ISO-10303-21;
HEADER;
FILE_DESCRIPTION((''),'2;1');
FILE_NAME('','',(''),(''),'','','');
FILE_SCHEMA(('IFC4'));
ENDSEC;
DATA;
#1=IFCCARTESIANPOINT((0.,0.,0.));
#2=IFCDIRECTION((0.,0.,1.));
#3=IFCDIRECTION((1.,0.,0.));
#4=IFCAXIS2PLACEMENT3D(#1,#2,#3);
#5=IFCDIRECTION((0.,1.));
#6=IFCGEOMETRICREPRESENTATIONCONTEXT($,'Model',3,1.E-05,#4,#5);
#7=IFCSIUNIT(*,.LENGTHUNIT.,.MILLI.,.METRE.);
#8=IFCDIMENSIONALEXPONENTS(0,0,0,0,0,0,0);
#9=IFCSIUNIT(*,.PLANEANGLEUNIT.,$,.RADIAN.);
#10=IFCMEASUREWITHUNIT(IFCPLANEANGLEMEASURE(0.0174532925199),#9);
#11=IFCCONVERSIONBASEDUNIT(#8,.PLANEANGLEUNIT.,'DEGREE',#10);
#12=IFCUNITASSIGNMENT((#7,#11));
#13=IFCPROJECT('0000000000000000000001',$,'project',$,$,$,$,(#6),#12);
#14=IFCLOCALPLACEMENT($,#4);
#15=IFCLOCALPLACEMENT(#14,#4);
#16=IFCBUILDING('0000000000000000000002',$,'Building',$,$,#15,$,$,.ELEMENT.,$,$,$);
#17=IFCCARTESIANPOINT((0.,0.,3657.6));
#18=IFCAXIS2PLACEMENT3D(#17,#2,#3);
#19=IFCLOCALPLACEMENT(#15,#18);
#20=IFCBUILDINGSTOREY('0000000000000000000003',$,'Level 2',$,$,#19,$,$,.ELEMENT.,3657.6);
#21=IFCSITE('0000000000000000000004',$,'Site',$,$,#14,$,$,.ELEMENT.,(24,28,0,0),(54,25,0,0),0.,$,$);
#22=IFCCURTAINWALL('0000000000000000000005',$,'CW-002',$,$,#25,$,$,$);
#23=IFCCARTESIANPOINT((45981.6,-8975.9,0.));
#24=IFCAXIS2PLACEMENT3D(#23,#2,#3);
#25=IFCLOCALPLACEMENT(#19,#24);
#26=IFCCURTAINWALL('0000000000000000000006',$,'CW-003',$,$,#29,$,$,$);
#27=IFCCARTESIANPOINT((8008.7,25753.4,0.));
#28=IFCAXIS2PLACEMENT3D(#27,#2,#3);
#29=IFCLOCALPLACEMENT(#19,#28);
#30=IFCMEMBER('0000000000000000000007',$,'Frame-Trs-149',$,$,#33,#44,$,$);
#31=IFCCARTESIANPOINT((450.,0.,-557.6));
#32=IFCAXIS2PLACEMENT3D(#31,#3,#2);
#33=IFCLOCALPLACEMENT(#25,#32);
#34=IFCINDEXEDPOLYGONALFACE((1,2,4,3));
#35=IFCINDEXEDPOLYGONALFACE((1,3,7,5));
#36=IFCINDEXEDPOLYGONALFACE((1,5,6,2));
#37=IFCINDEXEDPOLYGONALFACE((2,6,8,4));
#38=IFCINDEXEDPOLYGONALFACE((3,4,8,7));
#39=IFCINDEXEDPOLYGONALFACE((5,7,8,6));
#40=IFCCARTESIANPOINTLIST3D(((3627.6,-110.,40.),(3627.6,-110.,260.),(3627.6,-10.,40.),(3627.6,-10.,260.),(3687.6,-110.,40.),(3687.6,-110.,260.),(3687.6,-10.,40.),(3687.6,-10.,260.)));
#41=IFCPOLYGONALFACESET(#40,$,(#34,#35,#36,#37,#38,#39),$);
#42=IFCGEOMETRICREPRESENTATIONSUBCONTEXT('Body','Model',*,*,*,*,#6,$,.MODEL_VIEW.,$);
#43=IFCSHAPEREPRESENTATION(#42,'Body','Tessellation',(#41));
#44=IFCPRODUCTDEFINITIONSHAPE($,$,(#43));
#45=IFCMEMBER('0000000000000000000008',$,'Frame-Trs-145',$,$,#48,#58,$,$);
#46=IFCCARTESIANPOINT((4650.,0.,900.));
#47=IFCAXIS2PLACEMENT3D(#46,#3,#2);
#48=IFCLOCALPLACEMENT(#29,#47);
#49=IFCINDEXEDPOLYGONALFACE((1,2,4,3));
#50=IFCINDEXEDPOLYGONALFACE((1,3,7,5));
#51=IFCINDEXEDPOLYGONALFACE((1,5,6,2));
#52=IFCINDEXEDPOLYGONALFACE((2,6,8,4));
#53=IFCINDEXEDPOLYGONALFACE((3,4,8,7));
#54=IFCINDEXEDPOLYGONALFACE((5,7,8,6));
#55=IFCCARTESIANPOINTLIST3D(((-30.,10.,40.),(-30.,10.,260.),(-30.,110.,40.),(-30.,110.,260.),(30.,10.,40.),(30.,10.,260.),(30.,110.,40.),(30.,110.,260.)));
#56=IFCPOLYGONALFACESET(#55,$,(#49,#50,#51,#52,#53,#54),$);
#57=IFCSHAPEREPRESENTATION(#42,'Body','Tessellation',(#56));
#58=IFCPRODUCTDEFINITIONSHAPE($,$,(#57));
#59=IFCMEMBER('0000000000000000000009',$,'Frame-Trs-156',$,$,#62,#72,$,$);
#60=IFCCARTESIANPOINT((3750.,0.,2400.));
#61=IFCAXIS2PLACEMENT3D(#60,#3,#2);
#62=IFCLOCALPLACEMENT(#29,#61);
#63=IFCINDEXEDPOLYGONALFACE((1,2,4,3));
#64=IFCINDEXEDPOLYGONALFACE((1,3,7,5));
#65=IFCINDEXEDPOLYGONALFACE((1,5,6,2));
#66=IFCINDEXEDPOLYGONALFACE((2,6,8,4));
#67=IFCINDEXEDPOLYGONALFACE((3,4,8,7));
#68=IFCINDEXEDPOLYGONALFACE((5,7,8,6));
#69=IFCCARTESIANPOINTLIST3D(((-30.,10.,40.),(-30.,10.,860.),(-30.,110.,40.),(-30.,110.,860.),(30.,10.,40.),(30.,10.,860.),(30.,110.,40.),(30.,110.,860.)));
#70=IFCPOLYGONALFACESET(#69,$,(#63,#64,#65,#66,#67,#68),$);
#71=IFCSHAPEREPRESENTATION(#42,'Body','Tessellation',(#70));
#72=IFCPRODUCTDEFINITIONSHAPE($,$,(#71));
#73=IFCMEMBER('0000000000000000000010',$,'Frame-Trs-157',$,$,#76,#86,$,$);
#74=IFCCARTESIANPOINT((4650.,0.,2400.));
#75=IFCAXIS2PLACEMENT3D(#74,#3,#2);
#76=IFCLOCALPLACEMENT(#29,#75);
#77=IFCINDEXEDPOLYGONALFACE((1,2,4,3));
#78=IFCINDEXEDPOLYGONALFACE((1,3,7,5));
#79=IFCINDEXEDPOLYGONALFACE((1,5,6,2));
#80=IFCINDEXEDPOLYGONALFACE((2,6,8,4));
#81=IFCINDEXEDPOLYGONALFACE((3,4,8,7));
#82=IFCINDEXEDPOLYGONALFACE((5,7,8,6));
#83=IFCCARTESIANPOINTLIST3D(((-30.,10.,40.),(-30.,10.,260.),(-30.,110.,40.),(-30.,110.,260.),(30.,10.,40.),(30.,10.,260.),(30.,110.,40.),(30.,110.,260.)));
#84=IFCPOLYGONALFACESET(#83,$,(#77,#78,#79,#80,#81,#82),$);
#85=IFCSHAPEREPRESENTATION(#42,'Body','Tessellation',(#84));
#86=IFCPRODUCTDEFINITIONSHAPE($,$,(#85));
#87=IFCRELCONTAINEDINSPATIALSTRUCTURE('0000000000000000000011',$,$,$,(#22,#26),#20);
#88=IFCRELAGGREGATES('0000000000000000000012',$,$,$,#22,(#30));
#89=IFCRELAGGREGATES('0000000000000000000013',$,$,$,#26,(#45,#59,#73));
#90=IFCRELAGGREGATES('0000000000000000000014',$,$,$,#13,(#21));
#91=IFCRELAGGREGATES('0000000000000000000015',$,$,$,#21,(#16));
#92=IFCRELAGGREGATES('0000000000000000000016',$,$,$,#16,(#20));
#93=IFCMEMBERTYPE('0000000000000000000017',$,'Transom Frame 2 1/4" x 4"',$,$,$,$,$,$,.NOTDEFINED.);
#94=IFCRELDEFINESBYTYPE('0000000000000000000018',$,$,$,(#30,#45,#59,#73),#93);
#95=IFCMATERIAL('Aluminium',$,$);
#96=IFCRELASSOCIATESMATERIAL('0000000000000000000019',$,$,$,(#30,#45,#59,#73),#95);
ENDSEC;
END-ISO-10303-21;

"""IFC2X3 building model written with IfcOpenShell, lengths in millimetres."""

from ifc_helpers import new_model, entity, si_unit, converted_unit, direction, frame, origin_with_axes, place, context, subcontext, project, spatial, polyline, outline, extrude, material, type_object, element, aggregate, save


model = new_model("IFC2X3")

# Units and contexts
model_context = context("Model", 3, precision=1e-05, world=origin_with_axes(), true_north=direction((0.0, 1.0)))
body_context = subcontext(model_context, "Body", "Model", "MODEL_VIEW")
ifc_project = project(units=[si_unit("LENGTHUNIT", "METRE", prefix="MILLI"), converted_unit("PLANEANGLEUNIT", "DEGREE", entity("IfcPlaneAngleMeasure", 0.0174532925199), si_unit("PLANEANGLEUNIT", "RADIAN"), dimensions=[0, 0, 0, 0, 0, 0, 0])], contexts=[model_context])

# Site, building, storey
site_placement = place(None, origin_with_axes())
site = spatial("IfcSite", under=ifc_project, at=site_placement, Name="Site", CompositionType="ELEMENT", RefLatitude=(24, 28, 0, 0), RefLongitude=(54, 25, 0, 0), RefElevation=0.0)
building_placement = place(site_placement, origin_with_axes())
building = spatial("IfcBuilding", under=site, at=building_placement, Name="Building", CompositionType="ELEMENT")
storey_placement = place(building_placement, frame((0.0, 0.0, 3657.6), z_axis=(0.0, 0.0, 1.0), x_axis=(1.0, 0.0, 0.0)))
storey = spatial("IfcBuildingStorey", under=building, at=storey_placement, Name="Level 2", CompositionType="ELEMENT", Elevation=3657.6)

# Curtain walls
curtain_wall_1_placement = place(storey_placement, frame((45981.6, -8975.9, 0.0), z_axis=(0.0, 0.0, 1.0), x_axis=(1.0, 0.0, 0.0)))
curtain_wall_1 = element("IfcCurtainWall", 1, at=curtain_wall_1_placement, inside=storey, Name="CW-002")
ifc_material_1 = material(Name="Aluminium")
curtain_wall_2_placement = place(storey_placement, frame((8008.7, 25753.4, 0.0), z_axis=(0.0, 0.0, 1.0), x_axis=(1.0, 0.0, 0.0)))
curtain_wall_2 = element("IfcCurtainWall", 2, at=curtain_wall_2_placement, inside=storey, Name="CW-003")

# Members
member_type_1 = type_object("IfcMemberType", Name="Transom Frame 2 1/4\" x 4\"", PredefinedType="NOTDEFINED")
member_1_placement = place(curtain_wall_1_placement, frame((450.0, 0.0, -557.6), z_axis=(1.0, 0.0, 0.0), x_axis=(0.0, 0.0, 1.0)))
member_1 = element("IfcMember", 3, at=member_1_placement, type_object=member_type_1, material=ifc_material_1, Name="Frame-Trs-149", context=body_context, shape_type="SweptSolid", body=[
    extrude(outline(polyline([(-110.0, -3687.6), (-10.0, -3687.6), (-10.0, -3627.6), (-110.0, -3627.6), (-110.0, -3687.6)])), frame((0.0, 0.0, 40.0), z_axis=(0.0, 0.0, 1.0), x_axis=(0.0, 1.0, 0.0)), (0.0, 0.0, 1.0), 220.0),
])
member_2_placement = place(curtain_wall_2_placement, frame((4650.0, 0.0, 900.0), z_axis=(1.0, 0.0, 0.0), x_axis=(0.0, 0.0, 1.0)))
member_2 = element("IfcMember", 4, at=member_2_placement, type_object=member_type_1, material=ifc_material_1, Name="Frame-Trs-145", context=body_context, shape_type="SweptSolid", body=[
    extrude(outline(polyline([(110.0, -30.0), (110.0, 30.0), (10.0, 30.0), (10.0, -30.0), (110.0, -30.0)])), frame((0.0, 0.0, 40.0), z_axis=(0.0, 0.0, 1.0), x_axis=(0.0, 1.0, 0.0)), (0.0, 0.0, 1.0), 220.0),
])
member_3_placement = place(curtain_wall_2_placement, frame((3750.0, 0.0, 2400.0), z_axis=(1.0, 0.0, 0.0), x_axis=(0.0, 0.0, 1.0)))
member_3 = element("IfcMember", 5, at=member_3_placement, type_object=member_type_1, material=ifc_material_1, Name="Frame-Trs-156", context=body_context, shape_type="SweptSolid", body=[
    extrude(outline(polyline([(110.0, -30.0), (110.0, 30.0), (10.0, 30.0), (10.0, -30.0), (110.0, -30.0)])), frame((0.0, 0.0, 40.0), z_axis=(0.0, 0.0, 1.0), x_axis=(0.0, 1.0, 0.0)), (0.0, 0.0, 1.0), 820.0),
])
member_4_placement = place(curtain_wall_2_placement, frame((4650.0, 0.0, 2400.0), z_axis=(1.0, 0.0, 0.0), x_axis=(0.0, 0.0, 1.0)))
member_4 = element("IfcMember", 6, at=member_4_placement, type_object=member_type_1, material=ifc_material_1, Name="Frame-Trs-157", context=body_context, shape_type="SweptSolid", body=[
    extrude(outline(polyline([(110.0, -30.0), (110.0, 30.0), (10.0, 30.0), (10.0, -30.0), (110.0, -30.0)])), frame((0.0, 0.0, 40.0), z_axis=(0.0, 0.0, 1.0), x_axis=(0.0, 1.0, 0.0)), (0.0, 0.0, 1.0), 220.0),
])

aggregate(curtain_wall_1, [member_1])
aggregate(curtain_wall_2, [member_2, member_3, member_4])

save(model, "model.ifc")
